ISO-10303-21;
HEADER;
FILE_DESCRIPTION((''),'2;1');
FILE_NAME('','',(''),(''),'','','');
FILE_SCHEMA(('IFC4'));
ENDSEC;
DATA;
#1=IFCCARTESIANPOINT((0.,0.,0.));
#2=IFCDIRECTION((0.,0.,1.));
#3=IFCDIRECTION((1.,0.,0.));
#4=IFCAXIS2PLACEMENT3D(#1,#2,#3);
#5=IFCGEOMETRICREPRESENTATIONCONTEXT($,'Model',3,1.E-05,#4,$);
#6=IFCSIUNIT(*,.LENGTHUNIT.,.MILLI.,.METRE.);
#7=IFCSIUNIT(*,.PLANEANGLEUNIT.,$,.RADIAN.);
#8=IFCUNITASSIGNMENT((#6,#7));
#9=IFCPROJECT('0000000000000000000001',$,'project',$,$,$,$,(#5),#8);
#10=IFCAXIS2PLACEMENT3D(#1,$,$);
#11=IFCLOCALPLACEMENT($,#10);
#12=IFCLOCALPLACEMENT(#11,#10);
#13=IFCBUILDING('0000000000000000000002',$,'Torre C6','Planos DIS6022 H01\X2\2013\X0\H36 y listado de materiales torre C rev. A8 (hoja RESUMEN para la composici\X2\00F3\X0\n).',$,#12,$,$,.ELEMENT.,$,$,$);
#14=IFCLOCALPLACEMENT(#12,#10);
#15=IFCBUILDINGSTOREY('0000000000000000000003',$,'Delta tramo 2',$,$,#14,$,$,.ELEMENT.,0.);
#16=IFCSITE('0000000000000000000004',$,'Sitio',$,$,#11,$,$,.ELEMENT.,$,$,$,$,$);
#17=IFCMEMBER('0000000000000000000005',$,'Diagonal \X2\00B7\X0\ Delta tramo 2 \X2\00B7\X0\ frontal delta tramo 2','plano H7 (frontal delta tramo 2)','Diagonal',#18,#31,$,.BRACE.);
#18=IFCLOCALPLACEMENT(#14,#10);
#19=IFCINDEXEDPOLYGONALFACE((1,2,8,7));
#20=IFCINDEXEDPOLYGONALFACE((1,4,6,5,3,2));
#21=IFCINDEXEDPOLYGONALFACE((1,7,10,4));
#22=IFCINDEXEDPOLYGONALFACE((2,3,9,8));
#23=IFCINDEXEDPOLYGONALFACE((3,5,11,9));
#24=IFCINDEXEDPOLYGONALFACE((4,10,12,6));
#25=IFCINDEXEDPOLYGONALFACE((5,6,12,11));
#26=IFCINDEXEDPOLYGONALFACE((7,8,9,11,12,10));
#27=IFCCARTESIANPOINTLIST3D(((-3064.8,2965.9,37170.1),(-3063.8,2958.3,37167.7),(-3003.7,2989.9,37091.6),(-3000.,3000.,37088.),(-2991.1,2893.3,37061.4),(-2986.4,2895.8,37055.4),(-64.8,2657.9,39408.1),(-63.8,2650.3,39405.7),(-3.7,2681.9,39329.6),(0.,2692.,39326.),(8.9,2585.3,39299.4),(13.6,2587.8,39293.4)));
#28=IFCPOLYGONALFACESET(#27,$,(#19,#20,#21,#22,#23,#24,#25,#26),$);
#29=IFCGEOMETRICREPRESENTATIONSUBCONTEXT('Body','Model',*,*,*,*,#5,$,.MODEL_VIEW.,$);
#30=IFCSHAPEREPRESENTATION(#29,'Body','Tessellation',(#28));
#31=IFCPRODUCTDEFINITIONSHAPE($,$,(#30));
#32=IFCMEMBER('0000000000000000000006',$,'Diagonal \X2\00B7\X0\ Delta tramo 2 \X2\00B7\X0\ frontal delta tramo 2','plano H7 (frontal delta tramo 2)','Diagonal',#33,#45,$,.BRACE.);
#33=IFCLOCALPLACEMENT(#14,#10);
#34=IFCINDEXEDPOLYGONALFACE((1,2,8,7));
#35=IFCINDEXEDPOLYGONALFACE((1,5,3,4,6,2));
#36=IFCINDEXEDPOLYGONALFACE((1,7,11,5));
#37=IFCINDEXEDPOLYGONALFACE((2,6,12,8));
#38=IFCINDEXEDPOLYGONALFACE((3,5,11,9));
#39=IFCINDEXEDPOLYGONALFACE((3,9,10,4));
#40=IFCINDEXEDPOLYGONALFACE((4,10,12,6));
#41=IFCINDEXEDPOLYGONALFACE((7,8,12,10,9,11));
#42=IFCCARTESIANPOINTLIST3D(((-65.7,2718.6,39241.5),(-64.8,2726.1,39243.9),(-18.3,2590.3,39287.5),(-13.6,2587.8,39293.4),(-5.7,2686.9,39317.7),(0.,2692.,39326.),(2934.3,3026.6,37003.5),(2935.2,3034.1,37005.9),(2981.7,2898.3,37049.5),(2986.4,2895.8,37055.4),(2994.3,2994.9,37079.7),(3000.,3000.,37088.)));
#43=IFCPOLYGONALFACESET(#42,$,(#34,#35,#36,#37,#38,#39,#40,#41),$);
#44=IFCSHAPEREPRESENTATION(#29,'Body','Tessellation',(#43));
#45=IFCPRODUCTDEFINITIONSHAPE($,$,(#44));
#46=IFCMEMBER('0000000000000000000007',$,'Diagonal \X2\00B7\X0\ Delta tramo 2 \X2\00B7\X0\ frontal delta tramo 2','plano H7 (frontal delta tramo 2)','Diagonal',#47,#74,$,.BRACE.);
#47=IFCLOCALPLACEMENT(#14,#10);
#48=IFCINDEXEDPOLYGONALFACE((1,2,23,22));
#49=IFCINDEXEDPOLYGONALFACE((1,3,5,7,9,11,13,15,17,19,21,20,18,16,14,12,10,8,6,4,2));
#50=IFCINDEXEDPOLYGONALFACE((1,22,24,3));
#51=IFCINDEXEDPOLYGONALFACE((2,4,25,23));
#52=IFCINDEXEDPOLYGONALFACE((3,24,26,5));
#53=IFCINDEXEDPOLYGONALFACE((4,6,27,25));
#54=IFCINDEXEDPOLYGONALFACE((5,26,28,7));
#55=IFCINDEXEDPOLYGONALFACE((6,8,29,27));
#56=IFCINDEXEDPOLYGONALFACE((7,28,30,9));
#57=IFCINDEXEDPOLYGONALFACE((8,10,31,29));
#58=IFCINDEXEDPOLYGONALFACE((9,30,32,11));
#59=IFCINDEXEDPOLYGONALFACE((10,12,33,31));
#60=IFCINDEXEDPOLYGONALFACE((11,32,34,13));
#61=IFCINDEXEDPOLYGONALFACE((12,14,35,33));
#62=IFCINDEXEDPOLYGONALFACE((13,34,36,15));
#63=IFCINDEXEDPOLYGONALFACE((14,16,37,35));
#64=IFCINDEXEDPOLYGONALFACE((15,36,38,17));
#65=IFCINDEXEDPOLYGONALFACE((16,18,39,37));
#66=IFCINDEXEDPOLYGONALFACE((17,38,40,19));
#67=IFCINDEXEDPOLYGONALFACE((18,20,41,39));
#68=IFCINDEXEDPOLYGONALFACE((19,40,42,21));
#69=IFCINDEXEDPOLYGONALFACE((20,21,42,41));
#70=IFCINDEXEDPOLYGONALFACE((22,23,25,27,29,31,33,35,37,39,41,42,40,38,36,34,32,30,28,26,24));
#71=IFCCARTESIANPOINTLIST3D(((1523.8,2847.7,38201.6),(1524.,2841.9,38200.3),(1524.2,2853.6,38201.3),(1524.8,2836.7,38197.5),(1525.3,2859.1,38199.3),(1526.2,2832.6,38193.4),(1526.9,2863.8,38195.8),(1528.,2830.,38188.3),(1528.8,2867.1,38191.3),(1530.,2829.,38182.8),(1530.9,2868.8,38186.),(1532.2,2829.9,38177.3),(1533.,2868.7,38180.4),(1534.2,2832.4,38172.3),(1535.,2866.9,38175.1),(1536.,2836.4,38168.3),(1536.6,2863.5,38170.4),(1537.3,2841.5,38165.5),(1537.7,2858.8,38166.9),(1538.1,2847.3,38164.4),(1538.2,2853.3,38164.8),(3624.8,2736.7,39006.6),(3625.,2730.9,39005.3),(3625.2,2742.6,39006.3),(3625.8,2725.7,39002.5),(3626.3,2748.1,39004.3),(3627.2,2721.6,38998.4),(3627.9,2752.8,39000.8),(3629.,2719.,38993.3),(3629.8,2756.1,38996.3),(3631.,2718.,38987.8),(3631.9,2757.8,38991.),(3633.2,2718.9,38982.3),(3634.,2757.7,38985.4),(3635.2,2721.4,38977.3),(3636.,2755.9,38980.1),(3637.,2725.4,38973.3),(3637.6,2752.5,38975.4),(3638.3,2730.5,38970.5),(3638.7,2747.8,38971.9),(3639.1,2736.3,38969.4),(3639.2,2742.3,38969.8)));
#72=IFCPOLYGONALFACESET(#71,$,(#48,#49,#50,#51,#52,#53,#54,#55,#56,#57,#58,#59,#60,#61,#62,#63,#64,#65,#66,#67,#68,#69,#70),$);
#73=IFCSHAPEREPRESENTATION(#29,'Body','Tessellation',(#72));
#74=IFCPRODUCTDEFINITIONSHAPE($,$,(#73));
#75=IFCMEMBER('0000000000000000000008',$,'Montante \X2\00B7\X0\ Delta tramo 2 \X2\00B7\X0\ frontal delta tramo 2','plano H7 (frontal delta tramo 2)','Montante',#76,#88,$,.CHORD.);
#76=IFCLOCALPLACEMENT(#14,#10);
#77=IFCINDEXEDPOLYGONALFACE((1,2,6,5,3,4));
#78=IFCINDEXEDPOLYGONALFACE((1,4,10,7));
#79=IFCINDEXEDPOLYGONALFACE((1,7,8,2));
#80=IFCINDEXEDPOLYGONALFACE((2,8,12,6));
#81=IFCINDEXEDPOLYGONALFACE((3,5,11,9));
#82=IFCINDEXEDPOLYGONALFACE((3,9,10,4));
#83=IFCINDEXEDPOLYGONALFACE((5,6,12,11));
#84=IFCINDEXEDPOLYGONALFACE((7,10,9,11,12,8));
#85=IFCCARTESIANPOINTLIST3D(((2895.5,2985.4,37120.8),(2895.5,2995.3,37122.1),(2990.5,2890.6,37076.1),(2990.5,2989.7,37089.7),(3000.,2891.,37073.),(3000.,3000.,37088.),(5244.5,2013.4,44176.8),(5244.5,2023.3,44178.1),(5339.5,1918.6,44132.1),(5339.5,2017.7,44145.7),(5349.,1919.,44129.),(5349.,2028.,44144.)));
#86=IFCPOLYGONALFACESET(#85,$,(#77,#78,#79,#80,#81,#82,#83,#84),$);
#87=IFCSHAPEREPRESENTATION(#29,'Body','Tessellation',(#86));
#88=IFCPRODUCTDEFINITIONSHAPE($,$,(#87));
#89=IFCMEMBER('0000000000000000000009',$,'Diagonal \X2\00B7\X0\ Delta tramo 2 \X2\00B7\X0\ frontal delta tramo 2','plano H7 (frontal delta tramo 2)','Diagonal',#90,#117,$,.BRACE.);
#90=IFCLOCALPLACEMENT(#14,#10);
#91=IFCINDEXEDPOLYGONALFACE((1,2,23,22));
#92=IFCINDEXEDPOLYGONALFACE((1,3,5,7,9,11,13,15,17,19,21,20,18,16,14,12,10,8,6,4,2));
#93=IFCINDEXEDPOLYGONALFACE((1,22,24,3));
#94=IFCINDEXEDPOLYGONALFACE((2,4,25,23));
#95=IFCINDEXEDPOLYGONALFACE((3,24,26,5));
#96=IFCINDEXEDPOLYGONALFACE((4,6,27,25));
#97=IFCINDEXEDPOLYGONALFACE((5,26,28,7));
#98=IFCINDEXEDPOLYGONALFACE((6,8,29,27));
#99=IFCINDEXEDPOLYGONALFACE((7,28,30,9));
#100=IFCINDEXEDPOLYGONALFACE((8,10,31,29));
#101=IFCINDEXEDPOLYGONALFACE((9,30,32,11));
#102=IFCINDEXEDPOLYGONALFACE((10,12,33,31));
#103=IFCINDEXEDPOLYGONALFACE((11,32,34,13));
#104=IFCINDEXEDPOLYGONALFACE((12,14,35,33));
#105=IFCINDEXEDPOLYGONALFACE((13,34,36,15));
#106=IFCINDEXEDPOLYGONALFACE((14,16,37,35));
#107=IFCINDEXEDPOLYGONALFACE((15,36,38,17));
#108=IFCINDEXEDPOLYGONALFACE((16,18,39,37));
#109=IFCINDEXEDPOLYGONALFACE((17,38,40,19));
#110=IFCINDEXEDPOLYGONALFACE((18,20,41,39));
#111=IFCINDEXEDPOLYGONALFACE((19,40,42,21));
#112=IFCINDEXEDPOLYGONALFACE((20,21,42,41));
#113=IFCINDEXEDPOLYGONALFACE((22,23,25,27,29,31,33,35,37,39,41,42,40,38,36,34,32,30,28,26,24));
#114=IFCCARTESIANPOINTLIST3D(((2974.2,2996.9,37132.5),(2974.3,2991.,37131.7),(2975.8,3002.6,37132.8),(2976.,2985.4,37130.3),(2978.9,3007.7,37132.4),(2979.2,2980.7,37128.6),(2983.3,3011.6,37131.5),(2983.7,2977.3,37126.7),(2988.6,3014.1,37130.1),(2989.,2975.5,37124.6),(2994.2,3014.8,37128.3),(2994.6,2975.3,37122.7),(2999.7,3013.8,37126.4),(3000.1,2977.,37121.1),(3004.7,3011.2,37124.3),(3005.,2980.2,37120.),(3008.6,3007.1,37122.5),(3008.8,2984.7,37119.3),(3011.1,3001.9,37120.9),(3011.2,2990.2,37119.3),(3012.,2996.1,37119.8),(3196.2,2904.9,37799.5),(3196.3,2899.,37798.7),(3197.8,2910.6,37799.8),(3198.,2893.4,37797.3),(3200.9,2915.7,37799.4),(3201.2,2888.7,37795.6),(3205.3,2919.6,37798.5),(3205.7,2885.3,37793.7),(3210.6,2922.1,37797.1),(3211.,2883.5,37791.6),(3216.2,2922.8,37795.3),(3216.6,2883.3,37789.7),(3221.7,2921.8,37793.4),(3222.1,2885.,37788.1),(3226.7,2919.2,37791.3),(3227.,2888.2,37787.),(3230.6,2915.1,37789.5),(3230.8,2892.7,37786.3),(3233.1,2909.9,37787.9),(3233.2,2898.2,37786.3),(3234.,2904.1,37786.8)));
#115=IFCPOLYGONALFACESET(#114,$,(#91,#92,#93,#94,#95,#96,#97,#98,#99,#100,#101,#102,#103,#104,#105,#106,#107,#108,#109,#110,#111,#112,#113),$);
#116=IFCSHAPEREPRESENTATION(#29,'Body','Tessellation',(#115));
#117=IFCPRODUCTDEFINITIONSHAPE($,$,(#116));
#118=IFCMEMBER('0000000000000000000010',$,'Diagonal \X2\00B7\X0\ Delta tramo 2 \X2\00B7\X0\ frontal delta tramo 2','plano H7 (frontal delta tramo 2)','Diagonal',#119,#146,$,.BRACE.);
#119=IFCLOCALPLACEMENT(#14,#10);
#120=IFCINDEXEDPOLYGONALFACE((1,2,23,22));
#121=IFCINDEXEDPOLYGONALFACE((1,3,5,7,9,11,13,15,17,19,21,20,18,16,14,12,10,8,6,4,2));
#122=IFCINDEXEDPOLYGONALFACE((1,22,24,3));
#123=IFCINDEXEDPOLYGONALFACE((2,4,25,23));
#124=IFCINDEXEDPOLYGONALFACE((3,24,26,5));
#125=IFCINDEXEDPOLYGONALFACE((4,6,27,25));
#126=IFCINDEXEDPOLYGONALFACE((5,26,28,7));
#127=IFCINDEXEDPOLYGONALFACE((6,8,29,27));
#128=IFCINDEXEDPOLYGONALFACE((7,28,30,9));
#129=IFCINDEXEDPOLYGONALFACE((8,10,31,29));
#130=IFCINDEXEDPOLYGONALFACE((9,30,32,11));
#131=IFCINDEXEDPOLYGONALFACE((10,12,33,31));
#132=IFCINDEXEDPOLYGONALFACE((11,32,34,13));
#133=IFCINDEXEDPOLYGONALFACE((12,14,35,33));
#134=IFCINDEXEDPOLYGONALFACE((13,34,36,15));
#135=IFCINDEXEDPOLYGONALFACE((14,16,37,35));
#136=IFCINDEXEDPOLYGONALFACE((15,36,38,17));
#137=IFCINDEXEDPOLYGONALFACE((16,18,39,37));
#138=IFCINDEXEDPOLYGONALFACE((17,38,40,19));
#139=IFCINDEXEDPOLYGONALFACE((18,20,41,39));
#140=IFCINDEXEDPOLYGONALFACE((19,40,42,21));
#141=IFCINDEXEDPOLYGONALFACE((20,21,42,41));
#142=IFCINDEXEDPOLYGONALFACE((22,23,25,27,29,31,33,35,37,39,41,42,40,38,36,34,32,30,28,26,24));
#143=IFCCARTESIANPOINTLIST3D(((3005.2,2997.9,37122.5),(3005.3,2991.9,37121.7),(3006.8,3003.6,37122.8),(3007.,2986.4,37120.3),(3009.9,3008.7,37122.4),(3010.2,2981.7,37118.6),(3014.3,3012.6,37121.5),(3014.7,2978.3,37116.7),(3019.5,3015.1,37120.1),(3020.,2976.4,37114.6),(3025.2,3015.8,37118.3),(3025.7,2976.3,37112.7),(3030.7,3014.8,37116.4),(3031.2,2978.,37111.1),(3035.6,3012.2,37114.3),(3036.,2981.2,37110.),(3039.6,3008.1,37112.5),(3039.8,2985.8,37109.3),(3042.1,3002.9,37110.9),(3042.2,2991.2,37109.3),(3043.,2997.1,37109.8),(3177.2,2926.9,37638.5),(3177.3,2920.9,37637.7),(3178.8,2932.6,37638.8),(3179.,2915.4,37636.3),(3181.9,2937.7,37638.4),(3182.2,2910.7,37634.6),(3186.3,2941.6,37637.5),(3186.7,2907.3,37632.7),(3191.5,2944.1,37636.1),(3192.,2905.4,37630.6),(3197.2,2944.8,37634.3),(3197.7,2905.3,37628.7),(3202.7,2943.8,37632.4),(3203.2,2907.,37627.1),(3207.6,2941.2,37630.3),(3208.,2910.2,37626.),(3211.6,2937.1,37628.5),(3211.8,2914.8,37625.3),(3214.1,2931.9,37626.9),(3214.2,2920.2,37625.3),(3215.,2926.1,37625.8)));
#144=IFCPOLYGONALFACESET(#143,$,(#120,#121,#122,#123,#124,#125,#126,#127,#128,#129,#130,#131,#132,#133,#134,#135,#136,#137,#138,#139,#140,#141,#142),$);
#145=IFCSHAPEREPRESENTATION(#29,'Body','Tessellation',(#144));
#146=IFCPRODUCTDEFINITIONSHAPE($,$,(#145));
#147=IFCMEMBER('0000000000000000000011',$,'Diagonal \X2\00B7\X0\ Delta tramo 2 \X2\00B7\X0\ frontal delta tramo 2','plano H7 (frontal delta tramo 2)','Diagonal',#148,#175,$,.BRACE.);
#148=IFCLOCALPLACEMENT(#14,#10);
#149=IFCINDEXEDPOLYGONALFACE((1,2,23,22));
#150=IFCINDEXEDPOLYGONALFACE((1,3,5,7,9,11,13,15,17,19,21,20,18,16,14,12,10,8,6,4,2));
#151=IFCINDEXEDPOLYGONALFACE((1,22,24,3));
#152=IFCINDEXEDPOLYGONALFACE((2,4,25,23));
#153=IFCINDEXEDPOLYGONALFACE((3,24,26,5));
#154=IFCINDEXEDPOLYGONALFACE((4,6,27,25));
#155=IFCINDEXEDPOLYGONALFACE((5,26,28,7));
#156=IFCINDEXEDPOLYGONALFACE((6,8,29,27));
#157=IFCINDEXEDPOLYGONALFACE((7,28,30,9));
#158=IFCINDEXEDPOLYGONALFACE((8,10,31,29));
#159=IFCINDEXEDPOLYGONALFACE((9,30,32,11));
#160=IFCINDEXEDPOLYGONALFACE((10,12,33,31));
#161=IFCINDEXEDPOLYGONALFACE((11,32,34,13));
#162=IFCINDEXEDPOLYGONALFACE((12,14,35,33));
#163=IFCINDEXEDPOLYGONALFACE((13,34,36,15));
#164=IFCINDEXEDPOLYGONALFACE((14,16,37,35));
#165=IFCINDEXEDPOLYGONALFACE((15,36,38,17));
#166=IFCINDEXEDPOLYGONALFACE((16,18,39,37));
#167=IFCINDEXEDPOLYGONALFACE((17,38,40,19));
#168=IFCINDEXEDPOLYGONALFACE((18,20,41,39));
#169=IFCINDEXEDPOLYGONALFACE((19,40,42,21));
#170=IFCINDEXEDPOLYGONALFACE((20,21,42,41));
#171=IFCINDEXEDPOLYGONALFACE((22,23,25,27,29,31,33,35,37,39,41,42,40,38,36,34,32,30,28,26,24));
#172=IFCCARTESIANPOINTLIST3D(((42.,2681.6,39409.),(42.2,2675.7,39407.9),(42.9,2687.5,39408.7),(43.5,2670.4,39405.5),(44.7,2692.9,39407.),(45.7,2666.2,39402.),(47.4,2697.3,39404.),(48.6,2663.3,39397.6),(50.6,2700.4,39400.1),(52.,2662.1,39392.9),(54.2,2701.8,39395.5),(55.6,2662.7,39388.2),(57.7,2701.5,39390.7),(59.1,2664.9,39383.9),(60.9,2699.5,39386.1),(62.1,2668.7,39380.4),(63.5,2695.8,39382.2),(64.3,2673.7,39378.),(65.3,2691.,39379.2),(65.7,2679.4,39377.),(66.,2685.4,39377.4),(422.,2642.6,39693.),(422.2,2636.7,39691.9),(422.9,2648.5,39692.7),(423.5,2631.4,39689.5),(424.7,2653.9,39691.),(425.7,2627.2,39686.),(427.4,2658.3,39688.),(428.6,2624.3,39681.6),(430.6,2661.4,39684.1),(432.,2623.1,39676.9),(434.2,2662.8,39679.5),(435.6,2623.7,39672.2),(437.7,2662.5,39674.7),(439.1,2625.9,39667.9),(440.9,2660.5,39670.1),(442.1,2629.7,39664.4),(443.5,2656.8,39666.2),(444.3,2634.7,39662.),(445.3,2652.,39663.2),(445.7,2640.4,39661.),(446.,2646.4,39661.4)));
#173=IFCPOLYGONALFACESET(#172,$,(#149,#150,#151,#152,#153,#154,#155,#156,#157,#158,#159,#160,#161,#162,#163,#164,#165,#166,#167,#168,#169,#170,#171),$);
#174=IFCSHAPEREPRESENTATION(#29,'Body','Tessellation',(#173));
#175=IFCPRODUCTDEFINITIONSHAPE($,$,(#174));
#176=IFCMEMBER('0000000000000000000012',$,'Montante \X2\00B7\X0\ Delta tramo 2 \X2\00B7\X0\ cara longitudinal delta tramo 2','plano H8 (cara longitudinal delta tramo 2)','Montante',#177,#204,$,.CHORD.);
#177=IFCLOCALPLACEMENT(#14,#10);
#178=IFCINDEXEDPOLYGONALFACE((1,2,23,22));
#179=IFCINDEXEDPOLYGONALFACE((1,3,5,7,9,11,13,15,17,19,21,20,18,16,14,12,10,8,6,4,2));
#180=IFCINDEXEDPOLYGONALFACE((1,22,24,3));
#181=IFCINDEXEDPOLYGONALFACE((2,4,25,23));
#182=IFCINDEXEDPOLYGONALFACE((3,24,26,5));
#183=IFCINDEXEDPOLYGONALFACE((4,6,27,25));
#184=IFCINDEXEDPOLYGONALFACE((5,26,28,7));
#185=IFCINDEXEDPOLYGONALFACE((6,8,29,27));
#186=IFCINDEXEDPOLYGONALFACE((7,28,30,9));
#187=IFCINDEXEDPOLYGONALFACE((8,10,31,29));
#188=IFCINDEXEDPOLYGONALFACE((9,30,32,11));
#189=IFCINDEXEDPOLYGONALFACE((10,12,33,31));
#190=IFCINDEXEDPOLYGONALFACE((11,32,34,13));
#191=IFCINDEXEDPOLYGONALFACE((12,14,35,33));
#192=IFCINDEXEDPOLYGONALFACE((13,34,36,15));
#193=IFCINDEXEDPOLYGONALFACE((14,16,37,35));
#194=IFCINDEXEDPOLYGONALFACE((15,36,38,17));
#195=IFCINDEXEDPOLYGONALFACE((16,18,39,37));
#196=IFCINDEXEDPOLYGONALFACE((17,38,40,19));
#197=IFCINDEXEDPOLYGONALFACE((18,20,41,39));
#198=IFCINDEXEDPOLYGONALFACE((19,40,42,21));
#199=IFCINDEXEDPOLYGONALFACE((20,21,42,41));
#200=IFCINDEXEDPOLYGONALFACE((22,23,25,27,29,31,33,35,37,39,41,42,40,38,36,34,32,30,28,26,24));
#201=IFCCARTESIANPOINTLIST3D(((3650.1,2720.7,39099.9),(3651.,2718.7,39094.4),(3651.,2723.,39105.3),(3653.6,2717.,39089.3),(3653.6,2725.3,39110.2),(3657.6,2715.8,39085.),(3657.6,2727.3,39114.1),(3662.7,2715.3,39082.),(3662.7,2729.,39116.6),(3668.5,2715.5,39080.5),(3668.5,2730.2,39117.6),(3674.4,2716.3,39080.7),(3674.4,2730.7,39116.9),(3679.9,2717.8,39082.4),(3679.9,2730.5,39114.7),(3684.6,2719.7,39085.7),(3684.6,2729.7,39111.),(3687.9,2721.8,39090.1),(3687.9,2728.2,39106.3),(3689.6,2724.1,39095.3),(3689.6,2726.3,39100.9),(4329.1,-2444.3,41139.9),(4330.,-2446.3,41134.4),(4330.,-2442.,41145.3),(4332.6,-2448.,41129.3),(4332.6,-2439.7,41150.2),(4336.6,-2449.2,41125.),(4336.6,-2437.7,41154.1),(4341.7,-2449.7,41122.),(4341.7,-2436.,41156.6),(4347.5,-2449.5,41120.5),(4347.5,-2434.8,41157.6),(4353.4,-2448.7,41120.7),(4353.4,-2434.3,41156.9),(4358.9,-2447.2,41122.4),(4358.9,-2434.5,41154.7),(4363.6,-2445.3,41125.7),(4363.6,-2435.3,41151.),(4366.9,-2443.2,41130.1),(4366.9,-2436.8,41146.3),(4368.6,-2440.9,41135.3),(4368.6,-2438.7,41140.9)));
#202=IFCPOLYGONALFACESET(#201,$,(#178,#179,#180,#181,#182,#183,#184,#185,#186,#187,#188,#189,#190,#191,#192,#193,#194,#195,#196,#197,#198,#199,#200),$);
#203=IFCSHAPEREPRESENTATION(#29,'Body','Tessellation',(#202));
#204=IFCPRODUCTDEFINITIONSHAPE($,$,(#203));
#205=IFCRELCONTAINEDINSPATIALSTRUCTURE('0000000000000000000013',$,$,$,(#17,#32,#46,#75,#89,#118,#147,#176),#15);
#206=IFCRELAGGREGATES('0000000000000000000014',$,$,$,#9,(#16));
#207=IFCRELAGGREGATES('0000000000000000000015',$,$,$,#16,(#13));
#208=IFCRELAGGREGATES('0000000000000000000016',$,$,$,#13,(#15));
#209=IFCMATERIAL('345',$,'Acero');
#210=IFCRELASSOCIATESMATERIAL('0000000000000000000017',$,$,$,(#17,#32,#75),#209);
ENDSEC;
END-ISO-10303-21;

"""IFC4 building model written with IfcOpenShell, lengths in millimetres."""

from ifc_helpers import new_model, si_unit, frame, frame_2d, origin, origin_with_axes, place, context, subcontext, project, spatial, circle, l_section, extrude, material, element, save


model = new_model("IFC4")

# Units and contexts
model_context = context("Model", 3, precision=1e-05, world=origin_with_axes())
body_context = subcontext(model_context, "Body", "Model", "MODEL_VIEW")
ifc_project = project(units=[si_unit("LENGTHUNIT", "METRE", prefix="MILLI"), si_unit("PLANEANGLEUNIT", "RADIAN")], contexts=[model_context])

# Site, building, storey
site_placement = place(None, origin())
site = spatial("IfcSite", under=ifc_project, at=site_placement, Name="Sitio", CompositionType="ELEMENT")
building_placement = place(site_placement, origin())
building = spatial("IfcBuilding", under=site, at=building_placement, Name="Torre C6", Description="Planos DIS6022 H01–H36 y listado de materiales torre C rev. A8 (hoja RESUMEN para la composición).", CompositionType="ELEMENT")
storey_placement = place(building_placement, origin())
storey = spatial("IfcBuildingStorey", under=building, at=storey_placement, Name="Delta tramo 2", CompositionType="ELEMENT", Elevation=0.0)

# Members
ifc_material_1 = material(Name="345", Category="Acero")
member_1_placement = place(storey_placement, frame((0.0, 2692.0, 39326.0), z_axis=(-0.798836, 0.082014, -0.595932), x_axis=(0.123685, -0.947102, -0.29614)))
element("IfcMember", 1, at=member_1_placement, inside=storey, material=ifc_material_1, Name="Diagonal · Delta tramo 2 · frontal delta tramo 2", Description="plano H7 (frontal delta tramo 2)", ObjectType="Diagonal", PredefinedType="BRACE", context=body_context, shape_type="SweptSolid", body=[
    extrude(l_section(Depth=110.0, Width=110.0, Thickness=8.0, at=frame_2d((55.0, 55.0))), None, (0.0, 0.0, 1.0), 3755.5),
])
member_2_placement = place(storey_placement, frame((0.0, 2692.0, 39326.0), z_axis=(0.798836, 0.082014, -0.595932), x_axis=(-0.123685, -0.947102, -0.29614)))
element("IfcMember", 2, at=member_2_placement, inside=storey, material=ifc_material_1, Name="Diagonal · Delta tramo 2 · frontal delta tramo 2", Description="plano H7 (frontal delta tramo 2)", ObjectType="Diagonal", PredefinedType="BRACE", context=body_context, shape_type="SweptSolid", body=[
    extrude(l_section(Depth=110.0, Width=110.0, Thickness=8.0, at=frame_2d((55.0, 55.0))), None, (0.0, 0.0, 1.0), 3755.5),
])
member_3_placement = place(storey_placement, frame((1531.0, 2849.0, 38183.0), z_axis=(0.932669, -0.049275, 0.357353), x_axis=(-0.152133, -0.95195, 0.265794)))
element("IfcMember", 3, at=member_3_placement, inside=storey, Name="Diagonal · Delta tramo 2 · frontal delta tramo 2", Description="plano H7 (frontal delta tramo 2)", ObjectType="Diagonal", PredefinedType="BRACE", context=body_context, shape_type="SweptSolid", body=[
    extrude(circle(Radius=20.0), None, (0.0, 0.0, 1.0), 2252.7),
])
member_4_placement = place(storey_placement, frame((3000.0, 3000.0, 37088.0), z_axis=(0.313201, -0.1296, 0.940802), x_axis=(-0.949687, -0.042741, 0.310271)))
element("IfcMember", 4, at=member_4_placement, inside=storey, material=ifc_material_1, Name="Montante · Delta tramo 2 · frontal delta tramo 2", Description="plano H7 (frontal delta tramo 2)", ObjectType="Montante", PredefinedType="CHORD", context=body_context, shape_type="SweptSolid", body=[
    extrude(l_section(Depth=110.0, Width=110.0, Thickness=10.0, at=frame_2d((55.0, 55.0))), None, (0.0, 0.0, 1.0), 7500.0),
])
member_5_placement = place(storey_placement, frame((2993.0, 2995.0, 37126.0), z_axis=(0.313131, -0.129766, 0.940803), x_axis=(-0.688431, -0.713424, 0.13073)))
element("IfcMember", 5, at=member_5_placement, inside=storey, Name="Diagonal · Delta tramo 2 · frontal delta tramo 2", Description="plano H7 (frontal delta tramo 2)", ObjectType="Diagonal", PredefinedType="BRACE", context=body_context, shape_type="SweptSolid", body=[
    extrude(circle(Radius=20.0), None, (0.0, 0.0, 1.0), 709.0),
])
member_6_placement = place(storey_placement, frame((3024.0, 2996.0, 37116.0), z_axis=(0.313568, -0.129438, 0.940703), x_axis=(-0.687636, -0.71415, 0.130947)))
element("IfcMember", 6, at=member_6_placement, inside=storey, Name="Diagonal · Delta tramo 2 · frontal delta tramo 2", Description="plano H7 (frontal delta tramo 2)", ObjectType="Diagonal", PredefinedType="BRACE", context=body_context, shape_type="SweptSolid", body=[
    extrude(circle(Radius=20.0), None, (0.0, 0.0, 1.0), 548.5),
])
member_7_placement = place(storey_placement, frame((434.0, 2643.0, 39677.0), z_axis=(-0.798318, 0.081933, -0.596637), x_axis=(-0.098238, -0.995149, -0.005212)))
element("IfcMember", 7, at=member_7_placement, inside=storey, Name="Diagonal · Delta tramo 2 · frontal delta tramo 2", Description="plano H7 (frontal delta tramo 2)", ObjectType="Diagonal", PredefinedType="BRACE", context=body_context, shape_type="SweptSolid", body=[
    extrude(circle(Radius=20.0), None, (0.0, 0.0, 1.0), 476.0),
])
member_8_placement = place(storey_placement, frame((3670.0, 2723.0, 39099.0), z_axis=(0.121366, -0.923207, 0.364635), x_axis=(-0.992608, -0.112881, 0.044584)))
element("IfcMember", 8, at=member_8_placement, inside=storey, Name="Montante · Delta tramo 2 · cara longitudinal delta tramo 2", Description="plano H8 (cara longitudinal delta tramo 2)", ObjectType="Montante", PredefinedType="CHORD", context=body_context, shape_type="SweptSolid", body=[
    extrude(circle(Radius=20.0), None, (0.0, 0.0, 1.0), 5594.6),
])

save(model, "model.ifc")
